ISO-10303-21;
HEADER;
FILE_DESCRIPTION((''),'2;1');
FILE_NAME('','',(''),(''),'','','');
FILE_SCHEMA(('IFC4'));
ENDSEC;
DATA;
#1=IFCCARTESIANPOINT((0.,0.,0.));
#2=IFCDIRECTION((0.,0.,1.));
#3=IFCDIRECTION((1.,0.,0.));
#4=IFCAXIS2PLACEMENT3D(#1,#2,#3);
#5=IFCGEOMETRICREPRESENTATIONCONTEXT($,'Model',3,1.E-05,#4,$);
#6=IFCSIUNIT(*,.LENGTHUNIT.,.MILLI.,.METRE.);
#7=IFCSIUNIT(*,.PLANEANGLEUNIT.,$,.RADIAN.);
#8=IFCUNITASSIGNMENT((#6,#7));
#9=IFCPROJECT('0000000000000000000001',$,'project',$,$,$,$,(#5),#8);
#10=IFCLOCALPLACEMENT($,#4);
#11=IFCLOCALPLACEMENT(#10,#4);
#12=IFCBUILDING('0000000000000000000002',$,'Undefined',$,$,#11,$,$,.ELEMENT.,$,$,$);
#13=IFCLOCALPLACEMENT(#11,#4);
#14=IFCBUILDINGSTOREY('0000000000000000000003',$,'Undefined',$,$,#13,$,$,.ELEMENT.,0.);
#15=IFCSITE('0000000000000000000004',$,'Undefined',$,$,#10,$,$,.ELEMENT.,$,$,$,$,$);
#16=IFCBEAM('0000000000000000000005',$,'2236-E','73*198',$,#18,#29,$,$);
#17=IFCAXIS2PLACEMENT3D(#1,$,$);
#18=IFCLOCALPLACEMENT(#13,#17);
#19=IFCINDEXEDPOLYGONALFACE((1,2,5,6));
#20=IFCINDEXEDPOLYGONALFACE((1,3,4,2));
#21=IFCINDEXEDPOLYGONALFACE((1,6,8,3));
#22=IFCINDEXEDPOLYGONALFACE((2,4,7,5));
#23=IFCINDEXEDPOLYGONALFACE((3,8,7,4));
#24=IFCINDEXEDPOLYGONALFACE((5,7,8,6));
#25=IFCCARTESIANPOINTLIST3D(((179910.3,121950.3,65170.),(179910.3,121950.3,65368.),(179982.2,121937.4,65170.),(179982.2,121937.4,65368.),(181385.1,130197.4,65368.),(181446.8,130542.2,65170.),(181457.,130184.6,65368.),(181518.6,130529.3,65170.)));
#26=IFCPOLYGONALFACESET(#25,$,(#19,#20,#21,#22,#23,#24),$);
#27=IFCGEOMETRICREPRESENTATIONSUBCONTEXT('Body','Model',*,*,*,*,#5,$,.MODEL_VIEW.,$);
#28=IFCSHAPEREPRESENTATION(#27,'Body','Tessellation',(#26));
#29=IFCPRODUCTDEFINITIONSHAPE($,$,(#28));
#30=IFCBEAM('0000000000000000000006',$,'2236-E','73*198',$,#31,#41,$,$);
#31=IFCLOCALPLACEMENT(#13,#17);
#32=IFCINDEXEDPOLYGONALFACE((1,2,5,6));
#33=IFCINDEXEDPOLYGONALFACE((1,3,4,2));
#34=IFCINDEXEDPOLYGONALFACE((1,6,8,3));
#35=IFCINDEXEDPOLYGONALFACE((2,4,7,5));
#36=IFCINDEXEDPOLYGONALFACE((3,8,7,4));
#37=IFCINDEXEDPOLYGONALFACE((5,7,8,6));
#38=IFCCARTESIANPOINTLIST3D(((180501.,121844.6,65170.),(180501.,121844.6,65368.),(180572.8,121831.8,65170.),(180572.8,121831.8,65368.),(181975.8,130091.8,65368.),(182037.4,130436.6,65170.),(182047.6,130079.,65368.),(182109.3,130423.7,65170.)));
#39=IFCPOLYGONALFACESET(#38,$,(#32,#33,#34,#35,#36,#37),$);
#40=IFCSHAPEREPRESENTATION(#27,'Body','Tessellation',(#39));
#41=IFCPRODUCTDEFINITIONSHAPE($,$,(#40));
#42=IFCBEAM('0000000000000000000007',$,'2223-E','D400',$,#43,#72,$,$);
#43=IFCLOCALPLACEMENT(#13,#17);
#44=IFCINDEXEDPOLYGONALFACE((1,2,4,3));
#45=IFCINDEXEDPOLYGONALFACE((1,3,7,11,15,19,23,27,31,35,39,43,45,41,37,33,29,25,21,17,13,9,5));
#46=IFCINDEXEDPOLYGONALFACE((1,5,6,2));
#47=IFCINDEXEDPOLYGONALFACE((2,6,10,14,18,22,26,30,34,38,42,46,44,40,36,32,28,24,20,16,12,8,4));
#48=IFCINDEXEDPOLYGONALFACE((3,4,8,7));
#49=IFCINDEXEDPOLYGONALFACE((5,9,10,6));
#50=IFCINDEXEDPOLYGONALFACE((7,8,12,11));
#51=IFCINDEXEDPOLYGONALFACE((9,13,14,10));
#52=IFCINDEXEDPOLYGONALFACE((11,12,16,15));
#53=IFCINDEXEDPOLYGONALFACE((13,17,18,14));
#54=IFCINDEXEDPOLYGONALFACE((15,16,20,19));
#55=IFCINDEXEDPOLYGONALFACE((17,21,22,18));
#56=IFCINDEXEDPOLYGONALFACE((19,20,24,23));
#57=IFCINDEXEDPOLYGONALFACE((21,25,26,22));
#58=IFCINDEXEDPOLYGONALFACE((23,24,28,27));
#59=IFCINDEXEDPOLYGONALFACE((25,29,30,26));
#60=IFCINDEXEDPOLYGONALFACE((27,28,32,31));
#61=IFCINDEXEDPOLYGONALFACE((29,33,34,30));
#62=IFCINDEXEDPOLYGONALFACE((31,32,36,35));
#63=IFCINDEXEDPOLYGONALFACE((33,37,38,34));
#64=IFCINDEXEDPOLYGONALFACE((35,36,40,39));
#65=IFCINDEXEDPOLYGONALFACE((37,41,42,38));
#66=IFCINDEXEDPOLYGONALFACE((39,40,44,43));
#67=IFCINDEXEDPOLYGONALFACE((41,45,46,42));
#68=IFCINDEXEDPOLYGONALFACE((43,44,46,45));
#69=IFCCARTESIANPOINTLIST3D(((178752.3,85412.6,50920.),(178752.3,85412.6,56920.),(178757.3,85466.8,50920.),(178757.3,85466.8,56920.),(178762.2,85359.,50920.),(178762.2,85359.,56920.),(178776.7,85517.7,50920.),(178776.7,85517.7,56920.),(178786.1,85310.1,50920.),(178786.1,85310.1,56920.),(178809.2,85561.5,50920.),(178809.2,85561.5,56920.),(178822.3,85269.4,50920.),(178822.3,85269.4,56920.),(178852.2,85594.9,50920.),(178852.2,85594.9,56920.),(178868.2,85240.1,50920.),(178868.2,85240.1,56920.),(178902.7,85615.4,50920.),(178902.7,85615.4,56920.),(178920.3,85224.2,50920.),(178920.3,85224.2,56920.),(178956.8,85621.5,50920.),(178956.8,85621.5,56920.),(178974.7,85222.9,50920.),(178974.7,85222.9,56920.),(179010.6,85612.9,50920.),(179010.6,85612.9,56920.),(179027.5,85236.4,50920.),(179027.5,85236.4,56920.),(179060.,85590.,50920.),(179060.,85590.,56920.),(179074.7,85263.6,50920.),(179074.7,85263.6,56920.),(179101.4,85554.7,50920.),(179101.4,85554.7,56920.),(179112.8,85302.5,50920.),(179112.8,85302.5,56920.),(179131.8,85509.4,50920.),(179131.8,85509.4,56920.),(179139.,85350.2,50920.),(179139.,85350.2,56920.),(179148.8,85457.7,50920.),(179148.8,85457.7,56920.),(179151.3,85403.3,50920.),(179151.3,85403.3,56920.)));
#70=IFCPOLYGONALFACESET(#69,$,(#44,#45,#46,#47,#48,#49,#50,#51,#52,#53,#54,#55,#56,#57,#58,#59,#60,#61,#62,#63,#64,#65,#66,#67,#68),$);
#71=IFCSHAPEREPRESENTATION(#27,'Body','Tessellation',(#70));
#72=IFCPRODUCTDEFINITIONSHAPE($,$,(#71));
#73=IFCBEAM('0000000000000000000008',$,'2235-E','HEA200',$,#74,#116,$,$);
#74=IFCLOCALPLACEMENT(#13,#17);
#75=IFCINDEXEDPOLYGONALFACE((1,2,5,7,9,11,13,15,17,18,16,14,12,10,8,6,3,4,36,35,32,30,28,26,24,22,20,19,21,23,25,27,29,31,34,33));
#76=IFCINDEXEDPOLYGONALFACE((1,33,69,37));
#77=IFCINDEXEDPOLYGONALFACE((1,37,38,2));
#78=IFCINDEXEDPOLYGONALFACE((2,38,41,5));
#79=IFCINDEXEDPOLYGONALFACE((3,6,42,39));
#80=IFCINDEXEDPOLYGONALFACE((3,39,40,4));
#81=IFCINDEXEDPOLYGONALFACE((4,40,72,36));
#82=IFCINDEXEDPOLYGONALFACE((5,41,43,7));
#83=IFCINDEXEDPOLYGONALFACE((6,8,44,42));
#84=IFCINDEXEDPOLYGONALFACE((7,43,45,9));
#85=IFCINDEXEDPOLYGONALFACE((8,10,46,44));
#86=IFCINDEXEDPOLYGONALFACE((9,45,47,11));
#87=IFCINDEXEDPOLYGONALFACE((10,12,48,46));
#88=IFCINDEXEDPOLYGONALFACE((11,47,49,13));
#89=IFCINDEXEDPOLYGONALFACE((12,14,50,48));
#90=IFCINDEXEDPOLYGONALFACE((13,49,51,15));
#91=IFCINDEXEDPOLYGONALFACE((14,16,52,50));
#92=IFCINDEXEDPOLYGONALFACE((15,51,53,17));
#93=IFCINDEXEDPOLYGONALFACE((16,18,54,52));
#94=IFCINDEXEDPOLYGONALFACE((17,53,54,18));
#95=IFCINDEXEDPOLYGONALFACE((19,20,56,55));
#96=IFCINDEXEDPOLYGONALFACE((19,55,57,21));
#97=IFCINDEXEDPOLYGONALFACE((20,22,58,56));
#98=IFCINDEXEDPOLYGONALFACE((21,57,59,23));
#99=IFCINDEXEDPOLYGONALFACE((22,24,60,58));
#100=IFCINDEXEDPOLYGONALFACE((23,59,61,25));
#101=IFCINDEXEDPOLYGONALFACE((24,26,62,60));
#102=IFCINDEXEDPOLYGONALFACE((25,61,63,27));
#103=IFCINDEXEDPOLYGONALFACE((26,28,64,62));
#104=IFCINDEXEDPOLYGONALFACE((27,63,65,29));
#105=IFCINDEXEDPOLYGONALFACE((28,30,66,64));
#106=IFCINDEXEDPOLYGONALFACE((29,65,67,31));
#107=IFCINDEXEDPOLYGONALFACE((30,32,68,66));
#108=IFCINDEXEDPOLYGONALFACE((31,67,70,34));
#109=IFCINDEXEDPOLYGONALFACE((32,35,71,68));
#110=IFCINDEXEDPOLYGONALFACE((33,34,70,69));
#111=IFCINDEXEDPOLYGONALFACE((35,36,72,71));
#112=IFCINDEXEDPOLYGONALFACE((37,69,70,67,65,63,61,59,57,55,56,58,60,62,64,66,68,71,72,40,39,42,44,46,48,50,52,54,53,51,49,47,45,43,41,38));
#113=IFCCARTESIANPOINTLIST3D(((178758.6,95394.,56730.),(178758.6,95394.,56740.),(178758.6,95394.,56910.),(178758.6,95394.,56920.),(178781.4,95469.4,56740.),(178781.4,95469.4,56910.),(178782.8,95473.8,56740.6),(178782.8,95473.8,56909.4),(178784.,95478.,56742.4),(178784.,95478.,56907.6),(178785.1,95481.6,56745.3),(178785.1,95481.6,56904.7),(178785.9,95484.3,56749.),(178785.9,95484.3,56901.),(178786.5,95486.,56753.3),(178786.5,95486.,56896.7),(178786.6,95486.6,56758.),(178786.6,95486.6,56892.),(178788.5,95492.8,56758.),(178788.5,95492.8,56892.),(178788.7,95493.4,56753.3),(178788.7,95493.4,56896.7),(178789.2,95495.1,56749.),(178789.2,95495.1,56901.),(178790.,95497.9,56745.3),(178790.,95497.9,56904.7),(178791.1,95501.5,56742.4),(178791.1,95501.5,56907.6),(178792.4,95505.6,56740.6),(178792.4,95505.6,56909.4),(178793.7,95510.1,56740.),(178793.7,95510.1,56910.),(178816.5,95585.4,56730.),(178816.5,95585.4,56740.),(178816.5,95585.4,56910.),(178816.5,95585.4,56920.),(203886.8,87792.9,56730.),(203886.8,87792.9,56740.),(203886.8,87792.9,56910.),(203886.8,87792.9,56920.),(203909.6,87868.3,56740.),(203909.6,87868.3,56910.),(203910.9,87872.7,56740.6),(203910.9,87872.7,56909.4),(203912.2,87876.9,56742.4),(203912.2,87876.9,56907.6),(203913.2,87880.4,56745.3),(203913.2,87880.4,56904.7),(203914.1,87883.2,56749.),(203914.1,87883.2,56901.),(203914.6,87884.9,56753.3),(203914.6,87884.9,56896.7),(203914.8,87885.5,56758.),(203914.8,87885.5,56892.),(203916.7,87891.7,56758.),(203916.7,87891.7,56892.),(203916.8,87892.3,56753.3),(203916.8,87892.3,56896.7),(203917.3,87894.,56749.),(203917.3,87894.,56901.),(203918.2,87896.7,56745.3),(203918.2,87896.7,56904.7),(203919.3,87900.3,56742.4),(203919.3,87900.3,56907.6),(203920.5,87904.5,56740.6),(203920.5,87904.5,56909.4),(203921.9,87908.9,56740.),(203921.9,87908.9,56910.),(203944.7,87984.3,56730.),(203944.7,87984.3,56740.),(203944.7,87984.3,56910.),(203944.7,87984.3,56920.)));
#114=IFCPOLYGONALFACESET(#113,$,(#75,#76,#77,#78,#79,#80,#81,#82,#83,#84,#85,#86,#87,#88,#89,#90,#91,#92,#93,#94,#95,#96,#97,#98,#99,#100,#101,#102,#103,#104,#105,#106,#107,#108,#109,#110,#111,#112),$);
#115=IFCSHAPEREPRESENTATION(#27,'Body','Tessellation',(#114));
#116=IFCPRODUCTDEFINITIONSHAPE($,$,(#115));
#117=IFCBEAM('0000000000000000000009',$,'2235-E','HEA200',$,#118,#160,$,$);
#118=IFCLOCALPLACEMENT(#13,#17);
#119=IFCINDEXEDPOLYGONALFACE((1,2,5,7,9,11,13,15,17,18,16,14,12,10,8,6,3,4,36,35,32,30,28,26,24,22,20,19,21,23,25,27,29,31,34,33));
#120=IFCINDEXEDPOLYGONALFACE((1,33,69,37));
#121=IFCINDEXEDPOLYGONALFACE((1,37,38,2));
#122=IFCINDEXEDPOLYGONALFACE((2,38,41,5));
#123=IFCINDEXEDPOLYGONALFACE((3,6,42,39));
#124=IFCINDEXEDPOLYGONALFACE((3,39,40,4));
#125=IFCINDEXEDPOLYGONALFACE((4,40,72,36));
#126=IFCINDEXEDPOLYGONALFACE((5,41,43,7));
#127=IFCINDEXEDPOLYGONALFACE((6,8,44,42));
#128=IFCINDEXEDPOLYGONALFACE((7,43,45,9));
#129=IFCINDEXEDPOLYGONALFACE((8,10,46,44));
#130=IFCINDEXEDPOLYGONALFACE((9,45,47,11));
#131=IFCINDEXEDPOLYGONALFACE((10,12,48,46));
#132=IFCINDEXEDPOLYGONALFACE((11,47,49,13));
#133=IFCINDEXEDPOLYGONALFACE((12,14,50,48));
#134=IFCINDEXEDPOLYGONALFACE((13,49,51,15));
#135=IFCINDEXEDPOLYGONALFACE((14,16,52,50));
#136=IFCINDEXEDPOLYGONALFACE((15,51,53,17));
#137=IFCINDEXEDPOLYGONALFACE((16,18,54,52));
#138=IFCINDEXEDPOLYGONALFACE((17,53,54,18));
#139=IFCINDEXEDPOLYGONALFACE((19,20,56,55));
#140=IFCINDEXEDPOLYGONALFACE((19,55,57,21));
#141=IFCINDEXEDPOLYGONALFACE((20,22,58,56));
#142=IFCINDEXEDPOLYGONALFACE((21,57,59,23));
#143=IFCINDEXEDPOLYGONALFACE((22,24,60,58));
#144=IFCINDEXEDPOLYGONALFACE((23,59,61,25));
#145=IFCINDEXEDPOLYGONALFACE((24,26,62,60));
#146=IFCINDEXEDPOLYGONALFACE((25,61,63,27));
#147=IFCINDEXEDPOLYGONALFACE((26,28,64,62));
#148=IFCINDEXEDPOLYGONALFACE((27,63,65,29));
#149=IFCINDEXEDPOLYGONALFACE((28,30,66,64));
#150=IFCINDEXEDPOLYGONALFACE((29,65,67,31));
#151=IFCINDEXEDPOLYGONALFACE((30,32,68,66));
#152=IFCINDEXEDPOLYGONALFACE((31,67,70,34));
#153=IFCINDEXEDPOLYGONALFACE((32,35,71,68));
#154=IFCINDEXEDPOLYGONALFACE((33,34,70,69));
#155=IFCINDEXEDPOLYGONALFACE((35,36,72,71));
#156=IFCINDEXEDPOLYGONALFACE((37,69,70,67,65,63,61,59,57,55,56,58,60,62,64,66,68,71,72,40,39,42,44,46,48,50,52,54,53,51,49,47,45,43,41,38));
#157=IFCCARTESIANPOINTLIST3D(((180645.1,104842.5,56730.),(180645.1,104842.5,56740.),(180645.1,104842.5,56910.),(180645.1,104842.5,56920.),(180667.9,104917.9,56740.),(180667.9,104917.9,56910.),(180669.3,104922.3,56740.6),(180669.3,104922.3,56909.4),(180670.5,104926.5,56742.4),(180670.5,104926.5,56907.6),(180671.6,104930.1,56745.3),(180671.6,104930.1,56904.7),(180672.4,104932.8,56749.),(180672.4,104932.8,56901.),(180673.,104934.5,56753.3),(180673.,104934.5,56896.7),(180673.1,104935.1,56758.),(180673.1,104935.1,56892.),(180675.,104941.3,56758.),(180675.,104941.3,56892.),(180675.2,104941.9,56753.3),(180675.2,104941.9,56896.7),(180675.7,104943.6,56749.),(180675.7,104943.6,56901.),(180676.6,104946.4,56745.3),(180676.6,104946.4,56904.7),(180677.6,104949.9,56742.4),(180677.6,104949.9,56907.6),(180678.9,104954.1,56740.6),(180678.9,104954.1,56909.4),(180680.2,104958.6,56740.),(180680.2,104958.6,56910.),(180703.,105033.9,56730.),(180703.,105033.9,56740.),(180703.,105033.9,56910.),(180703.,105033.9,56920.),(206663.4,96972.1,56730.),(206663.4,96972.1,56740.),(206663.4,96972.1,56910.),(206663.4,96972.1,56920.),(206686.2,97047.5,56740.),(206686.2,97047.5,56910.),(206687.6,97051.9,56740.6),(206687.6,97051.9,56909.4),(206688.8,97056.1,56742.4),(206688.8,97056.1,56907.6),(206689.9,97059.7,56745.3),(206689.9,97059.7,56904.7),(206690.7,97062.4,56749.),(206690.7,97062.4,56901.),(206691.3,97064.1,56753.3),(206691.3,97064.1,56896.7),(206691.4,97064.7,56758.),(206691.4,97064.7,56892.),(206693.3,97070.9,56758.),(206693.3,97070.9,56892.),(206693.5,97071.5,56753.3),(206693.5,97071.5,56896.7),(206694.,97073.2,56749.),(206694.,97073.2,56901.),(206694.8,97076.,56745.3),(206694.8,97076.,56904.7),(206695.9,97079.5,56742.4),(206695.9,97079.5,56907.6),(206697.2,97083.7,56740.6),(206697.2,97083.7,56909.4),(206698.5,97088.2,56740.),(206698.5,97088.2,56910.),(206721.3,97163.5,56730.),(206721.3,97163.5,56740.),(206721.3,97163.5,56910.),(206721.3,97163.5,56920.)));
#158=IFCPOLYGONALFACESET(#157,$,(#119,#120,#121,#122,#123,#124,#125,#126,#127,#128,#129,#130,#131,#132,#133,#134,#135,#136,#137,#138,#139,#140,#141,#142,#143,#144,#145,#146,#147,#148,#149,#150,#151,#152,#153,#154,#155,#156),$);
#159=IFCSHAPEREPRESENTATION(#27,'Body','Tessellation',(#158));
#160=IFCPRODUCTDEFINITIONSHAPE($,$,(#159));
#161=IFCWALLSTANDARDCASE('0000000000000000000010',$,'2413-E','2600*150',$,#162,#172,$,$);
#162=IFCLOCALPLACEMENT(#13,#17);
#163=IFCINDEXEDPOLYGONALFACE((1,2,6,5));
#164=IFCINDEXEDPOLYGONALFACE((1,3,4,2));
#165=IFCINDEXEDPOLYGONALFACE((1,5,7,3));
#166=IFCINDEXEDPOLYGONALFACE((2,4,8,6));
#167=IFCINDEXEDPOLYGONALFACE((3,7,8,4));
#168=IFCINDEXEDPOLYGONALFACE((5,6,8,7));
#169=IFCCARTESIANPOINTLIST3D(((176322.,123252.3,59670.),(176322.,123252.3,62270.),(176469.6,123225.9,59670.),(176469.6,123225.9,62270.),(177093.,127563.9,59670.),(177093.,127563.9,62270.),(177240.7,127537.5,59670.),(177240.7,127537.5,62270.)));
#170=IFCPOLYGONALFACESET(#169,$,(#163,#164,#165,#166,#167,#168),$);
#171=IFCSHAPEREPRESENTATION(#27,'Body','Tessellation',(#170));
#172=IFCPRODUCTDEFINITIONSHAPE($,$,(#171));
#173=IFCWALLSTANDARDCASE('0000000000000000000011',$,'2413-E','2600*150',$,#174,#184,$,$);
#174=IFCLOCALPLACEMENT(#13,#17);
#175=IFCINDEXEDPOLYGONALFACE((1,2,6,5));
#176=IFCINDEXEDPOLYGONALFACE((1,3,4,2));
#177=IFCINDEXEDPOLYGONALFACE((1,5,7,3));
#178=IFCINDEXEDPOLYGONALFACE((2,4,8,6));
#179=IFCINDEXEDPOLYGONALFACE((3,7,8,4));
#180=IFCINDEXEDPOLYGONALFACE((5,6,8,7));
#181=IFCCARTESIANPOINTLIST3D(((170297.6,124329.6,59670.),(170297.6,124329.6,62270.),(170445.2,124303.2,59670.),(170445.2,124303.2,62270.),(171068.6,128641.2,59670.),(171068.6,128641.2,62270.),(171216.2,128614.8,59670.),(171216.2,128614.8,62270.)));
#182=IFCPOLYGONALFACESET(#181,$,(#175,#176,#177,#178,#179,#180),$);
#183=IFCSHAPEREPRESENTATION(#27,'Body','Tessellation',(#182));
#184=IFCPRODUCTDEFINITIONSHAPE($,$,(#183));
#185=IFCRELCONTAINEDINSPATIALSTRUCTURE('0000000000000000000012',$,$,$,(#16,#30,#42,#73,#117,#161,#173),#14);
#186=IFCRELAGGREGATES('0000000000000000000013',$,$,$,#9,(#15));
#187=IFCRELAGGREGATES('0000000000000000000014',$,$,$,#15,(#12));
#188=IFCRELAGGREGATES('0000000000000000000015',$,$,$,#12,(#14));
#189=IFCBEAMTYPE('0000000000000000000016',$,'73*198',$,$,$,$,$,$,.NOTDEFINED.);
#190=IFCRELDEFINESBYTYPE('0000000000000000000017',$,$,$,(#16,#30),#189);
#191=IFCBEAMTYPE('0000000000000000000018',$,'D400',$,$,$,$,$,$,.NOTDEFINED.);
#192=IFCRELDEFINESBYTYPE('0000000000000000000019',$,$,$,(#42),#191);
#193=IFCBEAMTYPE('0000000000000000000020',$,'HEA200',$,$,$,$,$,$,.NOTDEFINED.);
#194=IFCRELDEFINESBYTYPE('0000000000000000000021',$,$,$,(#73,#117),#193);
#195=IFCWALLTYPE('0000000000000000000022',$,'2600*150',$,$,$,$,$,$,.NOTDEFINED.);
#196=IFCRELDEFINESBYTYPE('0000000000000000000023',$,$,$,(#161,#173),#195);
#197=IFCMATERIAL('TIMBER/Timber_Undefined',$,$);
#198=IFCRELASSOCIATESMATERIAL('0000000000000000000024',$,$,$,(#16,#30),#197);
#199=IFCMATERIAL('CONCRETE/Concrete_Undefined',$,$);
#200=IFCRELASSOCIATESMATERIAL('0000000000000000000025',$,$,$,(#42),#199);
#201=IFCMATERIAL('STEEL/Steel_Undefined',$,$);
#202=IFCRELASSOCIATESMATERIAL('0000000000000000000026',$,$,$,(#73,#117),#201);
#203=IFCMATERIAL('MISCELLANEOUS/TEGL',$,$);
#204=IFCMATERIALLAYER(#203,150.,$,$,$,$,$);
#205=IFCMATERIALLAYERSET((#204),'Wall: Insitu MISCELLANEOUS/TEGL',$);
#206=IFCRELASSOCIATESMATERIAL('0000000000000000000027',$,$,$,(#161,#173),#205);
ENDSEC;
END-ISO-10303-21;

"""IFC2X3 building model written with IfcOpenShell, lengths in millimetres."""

from ifc_helpers import new_model, si_unit, frame, frame_2d, origin_with_axes, origin_2d_with_axis, place, context, subcontext, project, spatial, rectangle, circle, i_section, extrude, clip, halfspace, material, layer, layer_set, layer_usage, type_object, element, save


model = new_model("IFC2X3")

# Units and contexts
model_context = context("Model", 3, precision=1e-05, world=origin_with_axes())
body_context = subcontext(model_context, "Body", "Model", "MODEL_VIEW")
ifc_project = project(units=[si_unit("LENGTHUNIT", "METRE", prefix="MILLI"), si_unit("PLANEANGLEUNIT", "RADIAN")], contexts=[model_context])

# Site, building, storey
site_placement = place(None, origin_with_axes())
site = spatial("IfcSite", under=ifc_project, at=site_placement, Name="Undefined", CompositionType="ELEMENT")
building_placement = place(site_placement, origin_with_axes())
building = spatial("IfcBuilding", under=site, at=building_placement, Name="Undefined", CompositionType="ELEMENT")
storey_placement = place(building_placement, origin_with_axes())
storey = spatial("IfcBuildingStorey", under=building, at=storey_placement, Name="Undefined", CompositionType="ELEMENT", Elevation=0.0)

# Beams
ifc_material_1 = material(Name="TIMBER/Timber_Undefined")
beam_type_1 = type_object("IfcBeamType", Name="73*198", PredefinedType="NOTDEFINED")
for number, where, z_axis, x_axis, name in (
    (1, (179946.3, 121943.8, 65269.0), (-0.984385, 0.176032, 0.0), (0.176032, 0.984385, 0.0), "2236-E"),
    (2, (180536.9, 121838.2, 65269.0), (-0.984385, 0.176032, 0.0), (0.176032, 0.984385, 0.0), "2236-E"),
):
    element("IfcBeam", number, at=place(storey_placement, frame(where, z_axis=z_axis, x_axis=x_axis)), inside=storey, type_object=beam_type_1, material=ifc_material_1, Name=name, Description="73*198", context=body_context, shape_type="Clipping", body=[
        clip(extrude(rectangle(XDim=198.0, YDim=73.0, at=origin_2d_with_axis()), frame((14325.0, 0.0, 0.0), z_axis=(-1.0, 0.0, 0.0), x_axis=(0.0, -1.0, 0.0)), (0.0, 0.0, 1.0), 14325.0), halfspace(frame((8728.2, 99.0, 36.5), z_axis=(0.492144, -0.870514, 0.0), x_axis=(0.0, 0.0, -1.0)), False)),
    ])
ifc_material_2 = material(Name="CONCRETE/Concrete_Undefined")
beam_type_2 = type_object("IfcBeamType", Name="D400", PredefinedType="NOTDEFINED")
beam_1_placement = place(storey_placement, frame((178952.1, 85421.6, 50920.0), z_axis=(0.999728, -0.023321, 0.0), x_axis=(0.0, 0.0, 1.0)))
element("IfcBeam", 3, at=beam_1_placement, inside=storey, type_object=beam_type_2, material=ifc_material_2, Name="2223-E", Description="D400", context=body_context, shape_type="SweptSolid", body=[
    extrude(circle(Radius=200.0, at=origin_2d_with_axis()), frame((6000.0, 0.0, 0.0), z_axis=(-1.0, 0.0, 0.0), x_axis=(0.0, -1.0, 0.0)), (0.0, 0.0, 1.0), 6000.0),
])
ifc_material_3 = material(Name="STEEL/Steel_Undefined")
beam_type_3 = type_object("IfcBeamType", Name="HEA200", PredefinedType="NOTDEFINED")
beam_2_placement = place(storey_placement, frame((178787.6, 95489.7, 56825.0), z_axis=(0.0, 0.0, 1.0), x_axis=(0.957167, -0.289538, 0.0)))
element("IfcBeam", 4, at=beam_2_placement, inside=storey, type_object=beam_type_3, material=ifc_material_3, Name="2235-E", Description="HEA200", context=body_context, shape_type="SweptSolid", body=[
    extrude(i_section(OverallWidth=200.0, OverallDepth=190.0, WebThickness=6.5, FlangeThickness=10.0, FilletRadius=18.0, at=origin_2d_with_axis()), frame((26252.6, 0.0, 0.0), z_axis=(-1.0, 0.0, 0.0), x_axis=(0.0, -1.0, 0.0)), (0.0, 0.0, 1.0), 26252.6),
])
beam_3_placement = place(storey_placement, frame((180674.1, 104938.2, 56825.0), z_axis=(0.0, 0.0, 1.0), x_axis=(0.957167, -0.289538, 0.0)))
element("IfcBeam", 5, at=beam_3_placement, inside=storey, type_object=beam_type_3, material=ifc_material_3, Name="2235-E", Description="HEA200", context=body_context, shape_type="SweptSolid", body=[
    extrude(i_section(OverallWidth=200.0, OverallDepth=190.0, WebThickness=6.5, FlangeThickness=10.0, FilletRadius=18.0, at=origin_2d_with_axis()), frame((27182.6, 0.0, 0.0), z_axis=(-1.0, 0.0, 0.0), x_axis=(0.0, -1.0, 0.0)), (0.0, 0.0, 1.0), 27182.6),
])

# Walls
ifc_material_4 = material(Name="MISCELLANEOUS/TEGL")
ifc_layer_1 = layer(ifc_material_4, 150.0)
ifc_layer_set_1 = layer_set([ifc_layer_1], Name="Wall: Insitu MISCELLANEOUS/TEGL")
ifc_layer_usage_1 = layer_usage(ifc_layer_set_1, "AXIS2", "POSITIVE", -75.0)
wall_type_1 = type_object("IfcWallType", Name="2600*150", PredefinedType="NOTDEFINED")
wall_1_placement = place(storey_placement, frame((176395.8, 123239.1, 59670.0), z_axis=(0.0, 0.0, 1.0), x_axis=(0.176032, 0.984385, 0.0)))
element("IfcWallStandardCase", 6, at=wall_1_placement, inside=storey, type_object=wall_type_1, material=ifc_layer_usage_1, Name="2413-E", Description="2600*150", context=body_context, shape_type="SweptSolid", body=[
    extrude(rectangle(XDim=4380.0, YDim=150.0, at=frame_2d((0.0, 2190.0), x_axis=(0.0, -1.0))), frame((0.0, 0.0, 0.0), z_axis=(0.0, 0.0, 1.0), x_axis=(0.0, -1.0, 0.0)), (0.0, 0.0, 1.0), 2600.0),
])
ifc_layer_usage_2 = layer_usage(ifc_layer_set_1, "AXIS2", "POSITIVE", -75.0)
wall_2_placement = place(storey_placement, frame((170371.4, 124316.4, 59670.0), z_axis=(0.0, 0.0, 1.0), x_axis=(0.176032, 0.984385, 0.0)))
element("IfcWallStandardCase", 7, at=wall_2_placement, inside=storey, type_object=wall_type_1, material=ifc_layer_usage_2, Name="2413-E", Description="2600*150", context=body_context, shape_type="SweptSolid", body=[
    extrude(rectangle(XDim=4380.0, YDim=150.0, at=frame_2d((0.0, 2190.0), x_axis=(0.0, -1.0))), frame((0.0, 0.0, 0.0), z_axis=(0.0, 0.0, 1.0), x_axis=(0.0, -1.0, 0.0)), (0.0, 0.0, 1.0), 2600.0),
])

save(model, "model.ifc")
